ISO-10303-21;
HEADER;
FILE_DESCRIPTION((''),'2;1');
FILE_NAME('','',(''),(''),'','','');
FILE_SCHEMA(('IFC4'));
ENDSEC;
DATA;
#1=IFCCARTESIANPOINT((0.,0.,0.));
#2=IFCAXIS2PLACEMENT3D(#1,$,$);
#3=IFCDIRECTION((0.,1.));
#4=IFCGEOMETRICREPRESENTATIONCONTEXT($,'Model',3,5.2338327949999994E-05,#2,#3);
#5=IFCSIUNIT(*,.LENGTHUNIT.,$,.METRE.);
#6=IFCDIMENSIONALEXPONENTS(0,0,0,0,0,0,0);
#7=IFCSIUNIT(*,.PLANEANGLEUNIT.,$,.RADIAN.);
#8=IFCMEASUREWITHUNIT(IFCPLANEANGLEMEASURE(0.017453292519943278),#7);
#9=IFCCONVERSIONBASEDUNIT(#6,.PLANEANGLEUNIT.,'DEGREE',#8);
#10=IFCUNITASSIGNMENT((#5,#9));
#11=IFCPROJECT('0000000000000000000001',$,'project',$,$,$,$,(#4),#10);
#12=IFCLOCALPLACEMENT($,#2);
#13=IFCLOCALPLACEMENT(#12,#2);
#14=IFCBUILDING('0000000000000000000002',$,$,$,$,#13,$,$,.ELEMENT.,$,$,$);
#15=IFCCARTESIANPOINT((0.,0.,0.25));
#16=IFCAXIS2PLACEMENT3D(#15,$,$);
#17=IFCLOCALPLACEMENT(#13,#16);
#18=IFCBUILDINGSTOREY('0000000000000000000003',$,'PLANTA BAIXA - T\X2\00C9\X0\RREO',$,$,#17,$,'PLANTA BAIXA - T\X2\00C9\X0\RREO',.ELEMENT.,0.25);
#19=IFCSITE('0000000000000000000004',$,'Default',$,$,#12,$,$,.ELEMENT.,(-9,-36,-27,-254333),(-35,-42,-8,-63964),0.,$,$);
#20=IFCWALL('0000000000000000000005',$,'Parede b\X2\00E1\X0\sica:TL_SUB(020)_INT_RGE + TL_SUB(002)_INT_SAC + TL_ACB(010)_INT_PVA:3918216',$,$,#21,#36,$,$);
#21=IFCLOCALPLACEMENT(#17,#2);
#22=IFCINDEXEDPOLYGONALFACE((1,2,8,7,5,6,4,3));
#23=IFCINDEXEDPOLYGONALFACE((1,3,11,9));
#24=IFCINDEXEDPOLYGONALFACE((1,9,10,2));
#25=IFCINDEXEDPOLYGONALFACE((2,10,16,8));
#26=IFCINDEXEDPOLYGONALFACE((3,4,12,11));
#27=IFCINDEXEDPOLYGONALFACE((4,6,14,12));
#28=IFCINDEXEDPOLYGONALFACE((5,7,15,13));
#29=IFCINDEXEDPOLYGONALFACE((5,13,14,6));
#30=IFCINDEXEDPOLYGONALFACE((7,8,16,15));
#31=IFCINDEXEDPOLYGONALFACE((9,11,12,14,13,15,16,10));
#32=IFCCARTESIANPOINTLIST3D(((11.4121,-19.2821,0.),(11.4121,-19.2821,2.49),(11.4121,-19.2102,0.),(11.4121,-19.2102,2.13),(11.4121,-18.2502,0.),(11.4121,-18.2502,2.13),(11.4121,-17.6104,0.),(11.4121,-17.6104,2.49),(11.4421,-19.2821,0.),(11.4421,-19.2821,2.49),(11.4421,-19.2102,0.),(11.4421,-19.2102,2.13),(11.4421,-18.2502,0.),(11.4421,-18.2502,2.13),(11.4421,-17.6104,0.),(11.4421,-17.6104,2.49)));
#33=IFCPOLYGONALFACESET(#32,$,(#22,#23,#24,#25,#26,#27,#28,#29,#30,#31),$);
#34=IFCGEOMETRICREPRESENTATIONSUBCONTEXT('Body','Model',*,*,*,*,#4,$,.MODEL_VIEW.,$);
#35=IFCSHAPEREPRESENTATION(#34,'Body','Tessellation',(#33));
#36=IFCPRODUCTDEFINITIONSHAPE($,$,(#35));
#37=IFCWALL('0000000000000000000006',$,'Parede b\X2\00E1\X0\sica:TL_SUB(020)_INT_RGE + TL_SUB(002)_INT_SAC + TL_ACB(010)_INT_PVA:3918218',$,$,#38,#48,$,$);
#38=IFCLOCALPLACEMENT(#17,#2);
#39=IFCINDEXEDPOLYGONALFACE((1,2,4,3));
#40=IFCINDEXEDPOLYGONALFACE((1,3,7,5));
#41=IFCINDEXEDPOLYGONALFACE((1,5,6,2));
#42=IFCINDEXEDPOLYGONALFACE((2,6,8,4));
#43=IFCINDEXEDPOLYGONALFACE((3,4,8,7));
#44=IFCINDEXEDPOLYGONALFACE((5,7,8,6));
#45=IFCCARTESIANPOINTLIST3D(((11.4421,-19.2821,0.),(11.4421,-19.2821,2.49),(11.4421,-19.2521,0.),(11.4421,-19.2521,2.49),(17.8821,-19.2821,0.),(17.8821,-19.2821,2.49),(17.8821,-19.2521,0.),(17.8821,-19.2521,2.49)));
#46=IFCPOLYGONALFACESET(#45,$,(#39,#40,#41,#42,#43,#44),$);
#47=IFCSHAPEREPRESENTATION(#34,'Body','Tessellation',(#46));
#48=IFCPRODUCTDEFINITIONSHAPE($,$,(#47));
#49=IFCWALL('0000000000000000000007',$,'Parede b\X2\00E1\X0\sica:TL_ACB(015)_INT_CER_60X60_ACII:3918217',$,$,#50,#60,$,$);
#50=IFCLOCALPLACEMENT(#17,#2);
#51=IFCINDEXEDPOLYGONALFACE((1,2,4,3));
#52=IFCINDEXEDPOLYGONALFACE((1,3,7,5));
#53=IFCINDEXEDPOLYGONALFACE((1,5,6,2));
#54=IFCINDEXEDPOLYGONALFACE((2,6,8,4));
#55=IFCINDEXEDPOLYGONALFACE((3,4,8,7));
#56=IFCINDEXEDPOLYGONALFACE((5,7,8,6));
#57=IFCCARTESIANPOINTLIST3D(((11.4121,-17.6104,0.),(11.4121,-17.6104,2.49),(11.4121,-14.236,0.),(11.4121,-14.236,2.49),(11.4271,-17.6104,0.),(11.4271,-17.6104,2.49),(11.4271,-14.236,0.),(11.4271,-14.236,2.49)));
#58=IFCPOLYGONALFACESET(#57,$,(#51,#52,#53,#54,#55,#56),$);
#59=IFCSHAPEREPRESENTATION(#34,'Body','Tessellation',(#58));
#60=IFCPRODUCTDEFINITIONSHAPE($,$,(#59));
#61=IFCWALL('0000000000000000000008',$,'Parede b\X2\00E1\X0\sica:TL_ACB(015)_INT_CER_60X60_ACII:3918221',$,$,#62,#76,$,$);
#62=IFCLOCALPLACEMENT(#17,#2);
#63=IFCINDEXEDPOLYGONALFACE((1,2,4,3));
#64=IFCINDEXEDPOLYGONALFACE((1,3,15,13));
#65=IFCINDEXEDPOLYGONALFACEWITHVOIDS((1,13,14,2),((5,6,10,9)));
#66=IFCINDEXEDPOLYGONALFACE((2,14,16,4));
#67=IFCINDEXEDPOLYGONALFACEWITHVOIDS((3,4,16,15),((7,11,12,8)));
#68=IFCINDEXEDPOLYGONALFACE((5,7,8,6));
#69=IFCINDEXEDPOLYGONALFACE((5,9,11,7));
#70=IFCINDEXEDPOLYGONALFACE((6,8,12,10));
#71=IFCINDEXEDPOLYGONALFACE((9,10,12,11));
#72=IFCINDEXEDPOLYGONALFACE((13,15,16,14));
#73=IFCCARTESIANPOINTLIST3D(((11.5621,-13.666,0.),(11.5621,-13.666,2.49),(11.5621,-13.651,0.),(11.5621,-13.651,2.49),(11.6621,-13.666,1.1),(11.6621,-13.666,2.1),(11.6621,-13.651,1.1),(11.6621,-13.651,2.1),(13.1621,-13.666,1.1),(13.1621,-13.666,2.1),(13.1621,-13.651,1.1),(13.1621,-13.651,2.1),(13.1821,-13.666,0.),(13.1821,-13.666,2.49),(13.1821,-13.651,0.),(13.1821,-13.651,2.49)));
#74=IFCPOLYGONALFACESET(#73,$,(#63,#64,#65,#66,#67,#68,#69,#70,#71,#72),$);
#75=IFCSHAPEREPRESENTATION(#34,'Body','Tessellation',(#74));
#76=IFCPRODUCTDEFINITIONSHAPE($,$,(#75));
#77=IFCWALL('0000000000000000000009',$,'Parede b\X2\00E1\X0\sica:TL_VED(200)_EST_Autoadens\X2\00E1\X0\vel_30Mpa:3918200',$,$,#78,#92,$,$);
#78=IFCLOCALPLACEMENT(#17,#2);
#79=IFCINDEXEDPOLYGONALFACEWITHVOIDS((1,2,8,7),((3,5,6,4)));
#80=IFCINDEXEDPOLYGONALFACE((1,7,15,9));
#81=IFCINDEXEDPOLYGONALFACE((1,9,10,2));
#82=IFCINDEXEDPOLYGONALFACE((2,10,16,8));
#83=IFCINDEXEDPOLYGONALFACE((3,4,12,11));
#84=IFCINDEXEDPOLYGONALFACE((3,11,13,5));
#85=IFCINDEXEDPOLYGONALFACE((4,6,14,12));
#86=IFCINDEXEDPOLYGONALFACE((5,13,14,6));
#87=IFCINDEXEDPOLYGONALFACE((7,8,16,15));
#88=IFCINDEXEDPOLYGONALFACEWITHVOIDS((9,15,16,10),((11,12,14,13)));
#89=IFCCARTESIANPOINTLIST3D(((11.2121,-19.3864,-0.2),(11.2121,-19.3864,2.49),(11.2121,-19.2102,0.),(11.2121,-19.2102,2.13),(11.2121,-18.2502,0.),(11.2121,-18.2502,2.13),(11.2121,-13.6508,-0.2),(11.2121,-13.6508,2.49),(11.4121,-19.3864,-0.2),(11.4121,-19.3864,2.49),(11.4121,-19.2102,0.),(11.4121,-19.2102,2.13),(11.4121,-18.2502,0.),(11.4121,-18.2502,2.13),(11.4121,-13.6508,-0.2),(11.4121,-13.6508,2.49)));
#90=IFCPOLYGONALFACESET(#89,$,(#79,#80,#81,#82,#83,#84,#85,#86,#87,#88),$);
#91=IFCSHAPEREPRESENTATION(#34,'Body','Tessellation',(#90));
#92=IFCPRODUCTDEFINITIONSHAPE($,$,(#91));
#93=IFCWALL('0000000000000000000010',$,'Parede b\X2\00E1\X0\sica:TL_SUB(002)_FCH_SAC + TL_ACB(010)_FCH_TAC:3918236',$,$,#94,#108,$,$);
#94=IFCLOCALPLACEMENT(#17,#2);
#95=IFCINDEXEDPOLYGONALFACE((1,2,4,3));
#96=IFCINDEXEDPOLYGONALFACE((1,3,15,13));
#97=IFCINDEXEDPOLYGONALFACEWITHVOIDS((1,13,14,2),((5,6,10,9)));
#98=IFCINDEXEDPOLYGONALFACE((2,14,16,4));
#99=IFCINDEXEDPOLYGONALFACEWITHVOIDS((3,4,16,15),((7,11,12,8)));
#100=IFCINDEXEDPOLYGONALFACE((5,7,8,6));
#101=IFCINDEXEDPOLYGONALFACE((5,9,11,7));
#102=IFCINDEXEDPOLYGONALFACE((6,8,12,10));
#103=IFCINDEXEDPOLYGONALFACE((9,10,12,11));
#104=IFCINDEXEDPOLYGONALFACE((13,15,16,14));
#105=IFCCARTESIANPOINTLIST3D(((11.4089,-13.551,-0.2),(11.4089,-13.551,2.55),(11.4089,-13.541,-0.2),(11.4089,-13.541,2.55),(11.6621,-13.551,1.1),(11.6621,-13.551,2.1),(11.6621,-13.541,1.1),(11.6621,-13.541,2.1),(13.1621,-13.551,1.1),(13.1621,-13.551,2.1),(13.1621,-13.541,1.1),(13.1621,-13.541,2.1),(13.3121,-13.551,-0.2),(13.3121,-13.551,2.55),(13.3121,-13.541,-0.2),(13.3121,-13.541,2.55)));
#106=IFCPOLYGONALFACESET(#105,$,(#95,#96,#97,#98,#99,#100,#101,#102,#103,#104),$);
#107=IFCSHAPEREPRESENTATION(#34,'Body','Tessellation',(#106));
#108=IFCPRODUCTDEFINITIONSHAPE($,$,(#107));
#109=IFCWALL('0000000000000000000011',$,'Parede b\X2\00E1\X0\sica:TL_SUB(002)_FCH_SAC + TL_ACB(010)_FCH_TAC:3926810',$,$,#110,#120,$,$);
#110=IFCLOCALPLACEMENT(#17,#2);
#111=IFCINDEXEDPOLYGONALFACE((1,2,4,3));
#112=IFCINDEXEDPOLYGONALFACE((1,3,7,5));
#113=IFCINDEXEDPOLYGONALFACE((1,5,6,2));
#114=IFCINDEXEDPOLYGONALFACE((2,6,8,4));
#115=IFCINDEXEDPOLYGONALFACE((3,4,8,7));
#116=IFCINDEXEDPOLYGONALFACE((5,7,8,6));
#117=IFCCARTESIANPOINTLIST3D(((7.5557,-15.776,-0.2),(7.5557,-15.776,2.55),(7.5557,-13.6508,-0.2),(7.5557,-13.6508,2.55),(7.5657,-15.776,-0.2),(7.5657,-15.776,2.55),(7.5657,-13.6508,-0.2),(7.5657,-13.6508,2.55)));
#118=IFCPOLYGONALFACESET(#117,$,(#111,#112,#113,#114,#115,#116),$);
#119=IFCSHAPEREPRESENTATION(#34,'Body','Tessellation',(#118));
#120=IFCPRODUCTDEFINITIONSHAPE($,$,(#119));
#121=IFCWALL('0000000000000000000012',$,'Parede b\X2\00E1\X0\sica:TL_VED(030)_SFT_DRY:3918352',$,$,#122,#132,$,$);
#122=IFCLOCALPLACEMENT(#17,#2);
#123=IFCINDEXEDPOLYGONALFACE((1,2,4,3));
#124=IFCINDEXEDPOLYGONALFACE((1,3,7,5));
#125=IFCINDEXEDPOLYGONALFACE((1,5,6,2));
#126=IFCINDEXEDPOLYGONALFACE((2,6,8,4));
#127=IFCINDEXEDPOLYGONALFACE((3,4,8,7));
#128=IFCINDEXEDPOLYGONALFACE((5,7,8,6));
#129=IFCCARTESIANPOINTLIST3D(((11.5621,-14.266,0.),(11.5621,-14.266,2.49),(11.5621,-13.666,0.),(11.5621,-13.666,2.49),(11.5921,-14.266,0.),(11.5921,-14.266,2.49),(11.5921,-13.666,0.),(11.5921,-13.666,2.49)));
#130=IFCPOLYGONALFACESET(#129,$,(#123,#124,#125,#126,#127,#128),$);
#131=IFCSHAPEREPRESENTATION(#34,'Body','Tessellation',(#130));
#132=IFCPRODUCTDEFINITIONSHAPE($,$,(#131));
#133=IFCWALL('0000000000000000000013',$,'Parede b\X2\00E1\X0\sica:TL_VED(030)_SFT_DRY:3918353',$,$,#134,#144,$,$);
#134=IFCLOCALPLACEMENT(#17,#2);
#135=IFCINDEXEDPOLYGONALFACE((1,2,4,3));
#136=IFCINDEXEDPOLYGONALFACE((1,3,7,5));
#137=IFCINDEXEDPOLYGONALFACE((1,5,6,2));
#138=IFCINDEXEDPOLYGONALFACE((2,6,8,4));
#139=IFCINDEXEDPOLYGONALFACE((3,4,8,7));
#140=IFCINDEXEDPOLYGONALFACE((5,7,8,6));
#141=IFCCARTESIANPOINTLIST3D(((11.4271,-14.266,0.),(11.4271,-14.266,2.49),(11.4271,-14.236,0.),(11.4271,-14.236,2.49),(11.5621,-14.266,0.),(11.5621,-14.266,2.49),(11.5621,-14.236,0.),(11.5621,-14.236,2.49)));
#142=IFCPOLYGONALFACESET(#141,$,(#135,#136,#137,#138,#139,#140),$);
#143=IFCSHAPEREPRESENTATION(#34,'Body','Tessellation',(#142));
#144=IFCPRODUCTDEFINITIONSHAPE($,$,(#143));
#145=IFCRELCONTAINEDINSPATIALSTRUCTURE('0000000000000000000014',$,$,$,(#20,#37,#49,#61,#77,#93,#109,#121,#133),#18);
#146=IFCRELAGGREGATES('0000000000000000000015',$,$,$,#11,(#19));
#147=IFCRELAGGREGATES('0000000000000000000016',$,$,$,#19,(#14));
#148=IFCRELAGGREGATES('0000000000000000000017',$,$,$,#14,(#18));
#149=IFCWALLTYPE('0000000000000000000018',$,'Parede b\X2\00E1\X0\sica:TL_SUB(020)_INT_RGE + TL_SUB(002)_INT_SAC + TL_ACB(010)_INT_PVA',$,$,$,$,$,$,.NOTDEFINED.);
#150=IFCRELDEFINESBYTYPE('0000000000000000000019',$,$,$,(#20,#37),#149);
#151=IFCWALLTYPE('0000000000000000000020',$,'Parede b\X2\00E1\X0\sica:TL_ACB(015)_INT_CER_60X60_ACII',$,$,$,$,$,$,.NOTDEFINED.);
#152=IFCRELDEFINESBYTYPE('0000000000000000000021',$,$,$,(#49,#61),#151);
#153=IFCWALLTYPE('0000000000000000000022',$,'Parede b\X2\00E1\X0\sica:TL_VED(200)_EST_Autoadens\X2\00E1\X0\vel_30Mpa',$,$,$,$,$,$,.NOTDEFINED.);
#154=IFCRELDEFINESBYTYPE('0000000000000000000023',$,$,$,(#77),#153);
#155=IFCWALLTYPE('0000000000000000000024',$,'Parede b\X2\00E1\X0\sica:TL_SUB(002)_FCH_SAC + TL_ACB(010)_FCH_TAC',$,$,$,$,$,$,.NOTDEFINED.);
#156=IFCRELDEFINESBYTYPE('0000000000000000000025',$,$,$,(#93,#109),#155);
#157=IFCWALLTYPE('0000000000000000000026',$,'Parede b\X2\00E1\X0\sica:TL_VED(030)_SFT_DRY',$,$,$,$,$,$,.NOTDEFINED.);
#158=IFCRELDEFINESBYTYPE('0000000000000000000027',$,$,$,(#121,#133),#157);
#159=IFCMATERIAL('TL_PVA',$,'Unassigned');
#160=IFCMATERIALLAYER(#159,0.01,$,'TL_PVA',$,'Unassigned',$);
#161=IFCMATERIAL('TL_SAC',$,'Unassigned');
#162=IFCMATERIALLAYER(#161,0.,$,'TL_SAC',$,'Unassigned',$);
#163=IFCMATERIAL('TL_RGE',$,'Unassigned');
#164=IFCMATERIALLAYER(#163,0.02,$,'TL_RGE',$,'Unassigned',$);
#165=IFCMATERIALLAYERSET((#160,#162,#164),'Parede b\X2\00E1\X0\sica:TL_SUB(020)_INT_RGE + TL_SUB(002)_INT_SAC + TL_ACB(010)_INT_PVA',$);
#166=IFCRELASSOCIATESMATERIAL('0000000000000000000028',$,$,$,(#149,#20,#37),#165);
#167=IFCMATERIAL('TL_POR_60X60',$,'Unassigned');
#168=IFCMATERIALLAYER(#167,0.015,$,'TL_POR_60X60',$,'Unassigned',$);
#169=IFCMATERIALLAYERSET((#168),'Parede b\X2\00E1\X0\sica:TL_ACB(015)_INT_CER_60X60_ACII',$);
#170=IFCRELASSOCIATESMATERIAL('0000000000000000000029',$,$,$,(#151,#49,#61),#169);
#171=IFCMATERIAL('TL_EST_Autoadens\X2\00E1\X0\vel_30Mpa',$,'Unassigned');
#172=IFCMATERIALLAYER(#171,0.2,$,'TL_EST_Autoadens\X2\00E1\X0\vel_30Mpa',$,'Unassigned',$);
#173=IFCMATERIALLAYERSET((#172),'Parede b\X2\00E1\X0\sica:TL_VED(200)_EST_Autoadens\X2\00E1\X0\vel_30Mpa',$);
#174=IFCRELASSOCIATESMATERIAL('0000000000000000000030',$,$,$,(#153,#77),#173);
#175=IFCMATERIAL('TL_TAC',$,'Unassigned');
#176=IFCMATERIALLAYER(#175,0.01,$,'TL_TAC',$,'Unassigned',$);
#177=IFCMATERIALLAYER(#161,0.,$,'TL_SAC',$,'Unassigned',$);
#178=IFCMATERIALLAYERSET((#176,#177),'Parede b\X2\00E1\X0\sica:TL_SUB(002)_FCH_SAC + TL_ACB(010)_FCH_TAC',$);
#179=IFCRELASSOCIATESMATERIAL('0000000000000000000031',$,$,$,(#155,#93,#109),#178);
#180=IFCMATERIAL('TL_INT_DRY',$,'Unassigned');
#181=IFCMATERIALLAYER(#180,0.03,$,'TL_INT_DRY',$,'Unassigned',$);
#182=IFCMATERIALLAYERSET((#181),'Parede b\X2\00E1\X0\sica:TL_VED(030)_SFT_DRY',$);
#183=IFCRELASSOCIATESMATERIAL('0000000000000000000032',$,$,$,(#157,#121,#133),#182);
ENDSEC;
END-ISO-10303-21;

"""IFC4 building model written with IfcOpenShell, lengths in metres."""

from ifc_helpers import new_model, entity, si_unit, converted_unit, direction, frame, frame_2d, origin, place, context, subcontext, project, spatial, rectangle, extrude, material, layer, layer_set, layer_usage, type_object, element, save


model = new_model("IFC4")

# Units and contexts
model_context = context("Model", 3, precision=5.2338327949999994e-05, world=origin(), true_north=direction((0.0, 1.0)))
body_context = subcontext(model_context, "Body", "Model", "MODEL_VIEW")
ifc_project = project(units=[si_unit("LENGTHUNIT", "METRE"), converted_unit("PLANEANGLEUNIT", "DEGREE", entity("IfcPlaneAngleMeasure", 0.017453292519943278), si_unit("PLANEANGLEUNIT", "RADIAN"), dimensions=[0, 0, 0, 0, 0, 0, 0])], contexts=[model_context])

# Site, building, storey
site_placement = place(None, frame((0.0, 0.0, 0.0)))
site = spatial("IfcSite", under=ifc_project, at=site_placement, Name="Default", CompositionType="ELEMENT", RefLatitude=(-9, -36, -27, -254333), RefLongitude=(-35, -42, -8, -63964), RefElevation=0.0)
building_placement = place(site_placement, origin())
building = spatial("IfcBuilding", under=site, at=building_placement, CompositionType="ELEMENT")
storey_placement = place(building_placement, frame((0.0, 0.0, 0.25)))
storey = spatial("IfcBuildingStorey", under=building, at=storey_placement, Name="PLANTA BAIXA - TÉRREO", LongName="PLANTA BAIXA - TÉRREO", CompositionType="ELEMENT", Elevation=0.25)

# Shared definitions
ifc_material_1 = material(Name="TL_POR_60X60", Category="Unassigned")

# Shared definitions
ifc_material_2 = material(Name="TL_EST_Autoadensável_30Mpa", Category="Unassigned")

# Wall, opening
ifc_material_3 = material(Name="TL_PVA", Category="Unassigned")
ifc_layer_1 = layer(ifc_material_3, 0.01, Name="TL_PVA", Category="Unassigned")
ifc_material_4 = material(Name="TL_SAC", Category="Unassigned")
ifc_layer_2 = layer(ifc_material_4, 0.0, Name="TL_SAC", Category="Unassigned")
ifc_material_5 = material(Name="TL_RGE", Category="Unassigned")
ifc_layer_3 = layer(ifc_material_5, 0.02, Name="TL_RGE", Category="Unassigned")
ifc_layer_set_1 = layer_set([ifc_layer_1, ifc_layer_2, ifc_layer_3], Name="Parede básica:TL_SUB(020)_INT_RGE + TL_SUB(002)_INT_SAC + TL_ACB(010)_INT_PVA")
ifc_layer_usage_1 = layer_usage(ifc_layer_set_1, "AXIS2", "POSITIVE", -0.015)
wall_type_1 = type_object("IfcWallType", Name="Parede básica:TL_SUB(020)_INT_RGE + TL_SUB(002)_INT_SAC + TL_ACB(010)_INT_PVA", PredefinedType="NOTDEFINED", material=ifc_layer_set_1)
wall_1_placement = place(storey_placement, frame((11.4271, -19.2821, 0.0), z_axis=(0.0, 0.0, 1.0), x_axis=(0.0, 1.0, 0.0)))
wall_1 = element("IfcWall", 1, at=wall_1_placement, inside=storey, type_object=wall_type_1, material=ifc_layer_usage_1, Name="Parede básica:TL_SUB(020)_INT_RGE + TL_SUB(002)_INT_SAC + TL_ACB(010)_INT_PVA:3918216", context=body_context, shape_type="SweptSolid", body=[
    extrude(rectangle(XDim=1.6717, YDim=0.03, at=frame_2d((0.8359, 0.0), x_axis=(-1.0, 0.0))), origin(), (0.0, 0.0, 1.0), 2.49),
])
opening_1_placement = place(wall_1_placement, frame((19.2821, 11.4271, 0.0)))
element("IfcOpeningElement", 2, at=opening_1_placement, cuts=wall_1, PredefinedType="OPENING", context=body_context, shape_type="SweptSolid", body=[
    extrude(rectangle(XDim=2.13, YDim=0.96, at=frame_2d((0.0, 0.0), x_axis=(0.0, 1.0))), frame((-18.7302, -12.9361, 1.065), z_axis=(0.0, 1.0, 0.0), x_axis=(-1.0, 0.0, 0.0)), (0.0, 0.0, 1.0), 3.048),
])

# Walls
ifc_layer_usage_2 = layer_usage(ifc_layer_set_1, "AXIS2", "NEGATIVE", 0.015)
wall_2_placement = place(storey_placement, frame((11.4421, -19.2671, 0.0)))
element("IfcWall", 3, at=wall_2_placement, inside=storey, type_object=wall_type_1, material=ifc_layer_usage_2, Name="Parede básica:TL_SUB(020)_INT_RGE + TL_SUB(002)_INT_SAC + TL_ACB(010)_INT_PVA:3918218", context=body_context, shape_type="SweptSolid", body=[
    extrude(rectangle(XDim=6.44, YDim=0.03, at=frame_2d((3.22, 0.0), x_axis=(-1.0, 0.0))), origin(), (0.0, 0.0, 1.0), 2.49),
])
ifc_layer_4 = layer(ifc_material_1, 0.015, Name="TL_POR_60X60", Category="Unassigned")
ifc_layer_set_2 = layer_set([ifc_layer_4], Name="Parede básica:TL_ACB(015)_INT_CER_60X60_ACII")
ifc_layer_usage_3 = layer_usage(ifc_layer_set_2, "AXIS2", "POSITIVE", -0.0075)
wall_type_2 = type_object("IfcWallType", Name="Parede básica:TL_ACB(015)_INT_CER_60X60_ACII", PredefinedType="NOTDEFINED", material=ifc_layer_set_2)
wall_3_placement = place(storey_placement, frame((11.4196, -17.6104, 0.0), z_axis=(0.0, 0.0, 1.0), x_axis=(0.0, 1.0, 0.0)))
element("IfcWall", 4, at=wall_3_placement, inside=storey, type_object=wall_type_2, material=ifc_layer_usage_3, Name="Parede básica:TL_ACB(015)_INT_CER_60X60_ACII:3918217", context=body_context, shape_type="SweptSolid", body=[
    extrude(rectangle(XDim=3.3744, YDim=0.015, at=frame_2d((1.6872, 0.0), x_axis=(-1.0, 0.0))), origin(), (0.0, 0.0, 1.0), 2.49),
])

# Walls, openings
ifc_layer_usage_4 = layer_usage(ifc_layer_set_2, "AXIS2", "POSITIVE", -0.0075)
wall_4_placement = place(storey_placement, frame((11.5621, -13.6585, 0.0)))
wall_4 = element("IfcWall", 5, at=wall_4_placement, inside=storey, type_object=wall_type_2, material=ifc_layer_usage_4, Name="Parede básica:TL_ACB(015)_INT_CER_60X60_ACII:3918221", context=body_context, shape_type="SweptSolid", body=[
    extrude(rectangle(XDim=1.62, YDim=0.015, at=frame_2d((0.81, 0.0), x_axis=(-1.0, 0.0))), origin(), (0.0, 0.0, 1.0), 2.49),
])
opening_2_placement = place(wall_4_placement, frame((-11.5621, 13.6585, 1.1)))
element("IfcOpeningElement", 6, at=opening_2_placement, cuts=wall_4, PredefinedType="OPENING", context=body_context, shape_type="SweptSolid", body=[
    extrude(rectangle(XDim=1.0, YDim=1.5, at=frame_2d((0.0, 0.0), x_axis=(0.0, 1.0))), frame((12.4121, -15.175, 0.5), z_axis=(0.0, 1.0, 0.0), x_axis=(1.0, 0.0, 0.0)), (0.0, 0.0, 1.0), 3.048),
])
ifc_layer_5 = layer(ifc_material_2, 0.2, Name="TL_EST_Autoadensável_30Mpa", Category="Unassigned")
ifc_layer_set_3 = layer_set([ifc_layer_5], Name="Parede básica:TL_VED(200)_EST_Autoadensável_30Mpa")
ifc_layer_usage_5 = layer_usage(ifc_layer_set_3, "AXIS2", "POSITIVE", -0.1)
wall_type_3 = type_object("IfcWallType", Name="Parede básica:TL_VED(200)_EST_Autoadensável_30Mpa", PredefinedType="NOTDEFINED", material=ifc_layer_set_3)
wall_5_placement = place(storey_placement, frame((11.3121, -13.6508, -0.2), z_axis=(0.0, 0.0, 1.0), x_axis=(0.0, -1.0, 0.0)))
wall_5 = element("IfcWall", 7, at=wall_5_placement, inside=storey, type_object=wall_type_3, material=ifc_layer_usage_5, Name="Parede básica:TL_VED(200)_EST_Autoadensável_30Mpa:3918200", context=body_context, shape_type="SweptSolid", body=[
    extrude(rectangle(XDim=5.7355, YDim=0.2, at=frame_2d((2.8678, 0.0), x_axis=(-1.0, 0.0))), origin(), (0.0, 0.0, 1.0), 2.69),
])
opening_3_placement = place(wall_5_placement, frame((4.5993, -0.1, 0.2)))
element("IfcOpeningElement", 8, at=opening_3_placement, cuts=wall_5, PredefinedType="OPENING", context=body_context, shape_type="SweptSolid", body=[
    extrude(rectangle(XDim=2.13, YDim=0.96, at=frame_2d((1.065, 0.48), x_axis=(1.0, 0.0))), frame((0.0, 0.0, 0.0), z_axis=(0.0, 1.0, 0.0), x_axis=(0.0, 0.0, 1.0)), (0.0, 0.0, 1.0), 0.2),
])
ifc_material_6 = material(Name="TL_TAC", Category="Unassigned")
ifc_layer_6 = layer(ifc_material_6, 0.01, Name="TL_TAC", Category="Unassigned")
ifc_layer_7 = layer(ifc_material_4, 0.0, Name="TL_SAC", Category="Unassigned")
ifc_layer_set_4 = layer_set([ifc_layer_6, ifc_layer_7], Name="Parede básica:TL_SUB(002)_FCH_SAC + TL_ACB(010)_FCH_TAC")
ifc_layer_usage_6 = layer_usage(ifc_layer_set_4, "AXIS2", "POSITIVE", -0.005)
wall_type_4 = type_object("IfcWallType", Name="Parede básica:TL_SUB(002)_FCH_SAC + TL_ACB(010)_FCH_TAC", PredefinedType="NOTDEFINED", material=ifc_layer_set_4)
wall_6_placement = place(storey_placement, frame((11.4089, -13.546, -0.2)))
wall_6 = element("IfcWall", 9, at=wall_6_placement, inside=storey, type_object=wall_type_4, material=ifc_layer_usage_6, Name="Parede básica:TL_SUB(002)_FCH_SAC + TL_ACB(010)_FCH_TAC:3918236", context=body_context, shape_type="SweptSolid", body=[
    extrude(rectangle(XDim=1.9032, YDim=0.01, at=frame_2d((0.9516, 0.0), x_axis=(-1.0, 0.0))), origin(), (0.0, 0.0, 1.0), 2.75),
])
opening_4_placement = place(wall_6_placement, frame((-11.4089, 13.546, 1.3)))
element("IfcOpeningElement", 10, at=opening_4_placement, cuts=wall_6, PredefinedType="OPENING", context=body_context, shape_type="SweptSolid", body=[
    extrude(rectangle(XDim=1.0, YDim=1.5, at=frame_2d((0.0, 0.0), x_axis=(0.0, 1.0))), frame((12.4121, -15.175, 0.5), z_axis=(0.0, 1.0, 0.0), x_axis=(1.0, 0.0, 0.0)), (0.0, 0.0, 1.0), 3.048),
])

# Walls
ifc_layer_usage_7 = layer_usage(ifc_layer_set_4, "AXIS2", "POSITIVE", -0.005)
wall_7_placement = place(storey_placement, frame((7.5607, -13.6508, -0.2), z_axis=(0.0, 0.0, 1.0), x_axis=(0.0, -1.0, 0.0)))
element("IfcWall", 11, at=wall_7_placement, inside=storey, type_object=wall_type_4, material=ifc_layer_usage_7, Name="Parede básica:TL_SUB(002)_FCH_SAC + TL_ACB(010)_FCH_TAC:3926810", context=body_context, shape_type="SweptSolid", body=[
    extrude(rectangle(XDim=2.1251, YDim=0.01, at=frame_2d((1.0626, 0.0), x_axis=(-1.0, 0.0))), origin(), (0.0, 0.0, 1.0), 2.75),
])
ifc_material_7 = material(Name="TL_INT_DRY", Category="Unassigned")
ifc_layer_8 = layer(ifc_material_7, 0.03, Name="TL_INT_DRY", Category="Unassigned")
ifc_layer_set_5 = layer_set([ifc_layer_8], Name="Parede básica:TL_VED(030)_SFT_DRY")
ifc_layer_usage_8 = layer_usage(ifc_layer_set_5, "AXIS2", "NEGATIVE", 0.015)
wall_type_5 = type_object("IfcWallType", Name="Parede básica:TL_VED(030)_SFT_DRY", PredefinedType="NOTDEFINED", material=ifc_layer_set_5)
wall_8_placement = place(storey_placement, frame((11.5771, -13.666, 0.0), z_axis=(0.0, 0.0, 1.0), x_axis=(0.0, -1.0, 0.0)))
element("IfcWall", 12, at=wall_8_placement, inside=storey, type_object=wall_type_5, material=ifc_layer_usage_8, Name="Parede básica:TL_VED(030)_SFT_DRY:3918352", context=body_context, shape_type="SweptSolid", body=[
    extrude(rectangle(XDim=0.6, YDim=0.03, at=frame_2d((0.3, 0.0), x_axis=(-1.0, 0.0))), origin(), (0.0, 0.0, 1.0), 2.49),
])
ifc_layer_usage_9 = layer_usage(ifc_layer_set_5, "AXIS2", "NEGATIVE", 0.015)
wall_9_placement = place(storey_placement, frame((11.5621, -14.251, 0.0), z_axis=(0.0, 0.0, 1.0), x_axis=(-1.0, 0.0, 0.0)))
element("IfcWall", 13, at=wall_9_placement, inside=storey, type_object=wall_type_5, material=ifc_layer_usage_9, Name="Parede básica:TL_VED(030)_SFT_DRY:3918353", context=body_context, shape_type="SweptSolid", body=[
    extrude(rectangle(XDim=0.135, YDim=0.03, at=frame_2d((0.0675, 0.0), x_axis=(-1.0, 0.0))), origin(), (0.0, 0.0, 1.0), 2.49),
])

save(model, "model.ifc")
